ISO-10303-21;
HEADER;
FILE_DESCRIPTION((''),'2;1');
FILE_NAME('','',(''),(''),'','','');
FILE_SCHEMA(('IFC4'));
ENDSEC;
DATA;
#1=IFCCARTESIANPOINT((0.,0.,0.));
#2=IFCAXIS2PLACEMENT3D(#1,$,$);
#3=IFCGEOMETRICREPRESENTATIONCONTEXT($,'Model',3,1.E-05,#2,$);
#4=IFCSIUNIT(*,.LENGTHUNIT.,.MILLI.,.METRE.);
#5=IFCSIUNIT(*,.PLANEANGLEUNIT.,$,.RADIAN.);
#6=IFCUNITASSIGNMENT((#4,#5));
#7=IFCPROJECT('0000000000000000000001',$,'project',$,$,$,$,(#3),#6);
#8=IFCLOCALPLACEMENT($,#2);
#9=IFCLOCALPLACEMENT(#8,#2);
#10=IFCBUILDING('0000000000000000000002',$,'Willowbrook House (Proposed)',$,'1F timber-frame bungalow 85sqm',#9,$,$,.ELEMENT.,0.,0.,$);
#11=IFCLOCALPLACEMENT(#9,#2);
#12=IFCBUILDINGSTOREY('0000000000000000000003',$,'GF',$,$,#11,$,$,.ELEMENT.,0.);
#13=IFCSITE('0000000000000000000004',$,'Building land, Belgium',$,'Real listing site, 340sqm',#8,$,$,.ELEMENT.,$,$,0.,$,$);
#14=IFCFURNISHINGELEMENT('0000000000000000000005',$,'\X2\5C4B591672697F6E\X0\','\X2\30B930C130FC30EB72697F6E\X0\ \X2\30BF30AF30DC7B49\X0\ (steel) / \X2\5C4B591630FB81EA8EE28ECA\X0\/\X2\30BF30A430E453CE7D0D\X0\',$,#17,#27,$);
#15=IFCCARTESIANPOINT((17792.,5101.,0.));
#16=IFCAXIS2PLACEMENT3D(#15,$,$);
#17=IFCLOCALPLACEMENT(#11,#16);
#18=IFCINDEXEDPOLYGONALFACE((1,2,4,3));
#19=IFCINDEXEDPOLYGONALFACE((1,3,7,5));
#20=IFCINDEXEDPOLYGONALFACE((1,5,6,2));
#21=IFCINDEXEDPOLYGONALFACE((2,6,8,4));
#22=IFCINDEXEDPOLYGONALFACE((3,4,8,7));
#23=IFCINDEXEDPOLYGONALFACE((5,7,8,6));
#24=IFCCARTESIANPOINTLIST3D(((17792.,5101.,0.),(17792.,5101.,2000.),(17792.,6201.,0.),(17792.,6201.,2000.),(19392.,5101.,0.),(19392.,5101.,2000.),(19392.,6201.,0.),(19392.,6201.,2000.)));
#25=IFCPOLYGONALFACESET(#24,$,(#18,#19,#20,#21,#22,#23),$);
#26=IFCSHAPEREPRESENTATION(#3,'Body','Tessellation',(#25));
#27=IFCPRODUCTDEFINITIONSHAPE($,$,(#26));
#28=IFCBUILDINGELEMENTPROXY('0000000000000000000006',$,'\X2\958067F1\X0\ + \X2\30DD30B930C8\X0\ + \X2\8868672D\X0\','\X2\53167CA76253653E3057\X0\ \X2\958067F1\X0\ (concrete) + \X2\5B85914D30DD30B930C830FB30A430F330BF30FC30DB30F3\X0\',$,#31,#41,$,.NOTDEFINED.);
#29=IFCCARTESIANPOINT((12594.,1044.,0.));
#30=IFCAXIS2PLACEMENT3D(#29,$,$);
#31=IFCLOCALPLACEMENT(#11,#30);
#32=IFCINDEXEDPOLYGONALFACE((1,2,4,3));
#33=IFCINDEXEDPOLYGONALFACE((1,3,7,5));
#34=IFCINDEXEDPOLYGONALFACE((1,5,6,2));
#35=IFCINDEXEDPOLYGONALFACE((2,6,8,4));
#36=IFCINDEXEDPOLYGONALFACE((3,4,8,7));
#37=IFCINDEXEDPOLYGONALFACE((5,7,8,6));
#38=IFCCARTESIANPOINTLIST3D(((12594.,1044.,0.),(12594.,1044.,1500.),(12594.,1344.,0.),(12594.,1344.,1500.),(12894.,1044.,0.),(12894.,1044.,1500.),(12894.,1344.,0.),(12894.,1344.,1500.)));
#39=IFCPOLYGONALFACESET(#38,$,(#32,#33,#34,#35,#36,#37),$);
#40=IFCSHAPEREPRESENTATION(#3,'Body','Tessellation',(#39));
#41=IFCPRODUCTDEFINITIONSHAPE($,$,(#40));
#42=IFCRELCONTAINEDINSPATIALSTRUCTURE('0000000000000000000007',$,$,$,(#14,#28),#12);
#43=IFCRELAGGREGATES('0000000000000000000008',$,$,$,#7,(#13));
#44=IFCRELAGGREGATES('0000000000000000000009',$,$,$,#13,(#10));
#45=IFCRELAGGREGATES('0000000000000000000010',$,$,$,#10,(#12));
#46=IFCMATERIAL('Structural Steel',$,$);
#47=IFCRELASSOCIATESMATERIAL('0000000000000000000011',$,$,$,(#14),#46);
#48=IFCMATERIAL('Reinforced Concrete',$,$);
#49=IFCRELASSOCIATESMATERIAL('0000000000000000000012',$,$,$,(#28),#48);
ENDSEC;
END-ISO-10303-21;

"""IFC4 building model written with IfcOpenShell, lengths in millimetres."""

from ifc_helpers import new_model, si_unit, frame, frame_2d, origin, place, context, project, spatial, rectangle, extrude, material, element, save


model = new_model("IFC4")

# Units and contexts
model_context = context("Model", 3, precision=1e-05, world=origin())
ifc_project = project(units=[si_unit("LENGTHUNIT", "METRE", prefix="MILLI"), si_unit("PLANEANGLEUNIT", "RADIAN")], contexts=[model_context])

# Site, building, storey
site_placement = place(None, origin())
site = spatial("IfcSite", under=ifc_project, at=site_placement, Name="Building land, Belgium", ObjectType="Real listing site, 340sqm", CompositionType="ELEMENT", RefElevation=0.0)
building_placement = place(site_placement, origin())
building = spatial("IfcBuilding", under=site, at=building_placement, Name="Willowbrook House (Proposed)", ObjectType="1F timber-frame bungalow 85sqm", CompositionType="ELEMENT", ElevationOfRefHeight=0.0, ElevationOfTerrain=0.0)
storey_placement = place(building_placement, origin())
storey = spatial("IfcBuildingStorey", under=building, at=storey_placement, Name="GF", CompositionType="ELEMENT", Elevation=0.0)

# Shared definitions
ifc_material_1 = material(Name="Reinforced Concrete")

# Shared definitions
ifc_material_2 = material(Name="Structural Steel")

# Furnishing element
furnishing_1_placement = place(storey_placement, frame((17792.0, 5101.0, 0.0)))
element("IfcFurnishingElement", 1, at=furnishing_1_placement, inside=storey, material=ifc_material_2, Name="屋外物置", Description="スチール物置 タクボ等 (steel) / 屋外・自転車/タイヤ収納", context=model_context, shape_type="SweptSolid", body=[
    extrude(rectangle(XDim=1600.0, YDim=1100.0, at=frame_2d((800.0, 550.0))), frame((17792.0, 5101.0, 0.0)), (0.0, 0.0, 1.0), 2000.0),
])

# Building element proxy
proxy_placement = place(storey_placement, frame((12594.0, 1044.0, 0.0)))
element("IfcBuildingElementProxy", 2, at=proxy_placement, inside=storey, material=ifc_material_1, Name="門柱 + ポスト + 表札", Description="化粧打放し 門柱 (concrete) + 宅配ポスト・インターホン", PredefinedType="NOTDEFINED", context=model_context, shape_type="SweptSolid", body=[
    extrude(rectangle(XDim=300.0, YDim=300.0, at=frame_2d((150.0, 150.0))), frame((12594.0, 1044.0, 0.0)), (0.0, 0.0, 1.0), 1500.0),
])

save(model, "model.ifc")
